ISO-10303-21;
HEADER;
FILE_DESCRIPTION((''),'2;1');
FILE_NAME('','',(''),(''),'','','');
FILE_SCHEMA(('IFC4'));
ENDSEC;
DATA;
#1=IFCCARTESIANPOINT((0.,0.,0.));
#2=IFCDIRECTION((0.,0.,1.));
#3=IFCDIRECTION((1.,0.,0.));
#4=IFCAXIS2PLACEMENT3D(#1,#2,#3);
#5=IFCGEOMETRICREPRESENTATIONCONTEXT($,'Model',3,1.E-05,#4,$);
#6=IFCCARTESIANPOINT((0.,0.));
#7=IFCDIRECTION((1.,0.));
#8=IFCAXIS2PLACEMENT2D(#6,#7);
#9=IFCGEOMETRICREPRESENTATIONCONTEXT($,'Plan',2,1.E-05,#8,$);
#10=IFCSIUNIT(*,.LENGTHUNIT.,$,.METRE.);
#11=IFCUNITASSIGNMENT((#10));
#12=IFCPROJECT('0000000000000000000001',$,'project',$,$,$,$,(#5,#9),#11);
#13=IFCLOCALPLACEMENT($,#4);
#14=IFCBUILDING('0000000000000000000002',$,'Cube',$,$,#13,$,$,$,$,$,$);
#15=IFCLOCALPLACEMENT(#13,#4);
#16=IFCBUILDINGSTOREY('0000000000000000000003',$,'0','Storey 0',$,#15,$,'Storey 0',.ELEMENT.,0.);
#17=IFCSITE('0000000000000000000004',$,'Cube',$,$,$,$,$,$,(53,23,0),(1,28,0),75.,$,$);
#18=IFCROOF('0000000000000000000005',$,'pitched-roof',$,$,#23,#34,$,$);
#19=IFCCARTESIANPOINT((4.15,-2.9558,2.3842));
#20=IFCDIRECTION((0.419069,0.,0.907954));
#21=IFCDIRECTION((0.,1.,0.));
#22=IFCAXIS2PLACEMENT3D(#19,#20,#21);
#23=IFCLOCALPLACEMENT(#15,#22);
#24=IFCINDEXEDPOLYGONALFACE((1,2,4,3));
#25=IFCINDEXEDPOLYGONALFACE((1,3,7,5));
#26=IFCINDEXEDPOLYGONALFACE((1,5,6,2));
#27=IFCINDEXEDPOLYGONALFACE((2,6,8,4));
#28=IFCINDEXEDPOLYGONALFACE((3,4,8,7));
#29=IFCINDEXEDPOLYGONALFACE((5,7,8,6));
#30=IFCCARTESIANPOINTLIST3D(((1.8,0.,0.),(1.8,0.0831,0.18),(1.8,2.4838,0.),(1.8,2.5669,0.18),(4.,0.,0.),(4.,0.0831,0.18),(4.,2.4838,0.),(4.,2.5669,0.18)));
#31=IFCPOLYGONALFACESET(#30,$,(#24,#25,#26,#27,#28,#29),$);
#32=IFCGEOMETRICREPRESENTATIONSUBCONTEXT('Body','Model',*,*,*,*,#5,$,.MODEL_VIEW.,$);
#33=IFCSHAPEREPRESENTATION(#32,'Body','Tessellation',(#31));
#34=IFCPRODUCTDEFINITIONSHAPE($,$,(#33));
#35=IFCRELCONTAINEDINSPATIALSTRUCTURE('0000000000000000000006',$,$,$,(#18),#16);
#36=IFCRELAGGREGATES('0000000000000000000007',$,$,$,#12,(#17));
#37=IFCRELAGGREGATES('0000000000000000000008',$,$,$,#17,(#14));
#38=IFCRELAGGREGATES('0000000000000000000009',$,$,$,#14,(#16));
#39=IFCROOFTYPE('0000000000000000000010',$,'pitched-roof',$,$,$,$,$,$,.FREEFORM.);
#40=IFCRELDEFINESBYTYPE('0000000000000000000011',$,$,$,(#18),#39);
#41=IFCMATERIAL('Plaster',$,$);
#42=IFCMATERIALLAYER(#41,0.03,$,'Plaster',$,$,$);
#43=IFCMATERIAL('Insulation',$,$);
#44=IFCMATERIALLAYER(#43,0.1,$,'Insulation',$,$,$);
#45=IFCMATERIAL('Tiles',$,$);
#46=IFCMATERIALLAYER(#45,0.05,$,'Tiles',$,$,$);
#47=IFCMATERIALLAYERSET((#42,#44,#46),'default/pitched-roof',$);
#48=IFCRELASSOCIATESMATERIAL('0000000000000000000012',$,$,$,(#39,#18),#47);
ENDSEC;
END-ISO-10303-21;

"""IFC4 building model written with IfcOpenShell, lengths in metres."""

from ifc_helpers import new_model, si_unit, frame, origin_with_axes, origin_2d_with_axis, place, context, subcontext, project, spatial, indexed_curve, outline, extrude, material, layer, layer_set, layer_usage, type_object, element, save


model = new_model("IFC4")

# Units and contexts
model_context = context("Model", 3, precision=1e-05, world=origin_with_axes())
plan_context = context("Plan", 2, precision=1e-05, world=origin_2d_with_axis())
body_context = subcontext(model_context, "Body", "Model", "MODEL_VIEW")
ifc_project = project(units=[si_unit("LENGTHUNIT", "METRE")], contexts=[model_context, plan_context])

# Site, building, storey
site = spatial("IfcSite", under=ifc_project, Name="Cube", RefLatitude=(53, 23, 0), RefLongitude=(1, 28, 0), RefElevation=75.0)
building_placement = place(None, origin_with_axes())
building = spatial("IfcBuilding", under=site, at=building_placement, Name="Cube")
storey_placement = place(building_placement, origin_with_axes())
storey = spatial("IfcBuildingStorey", under=building, at=storey_placement, Name="0", Description="Storey 0", LongName="Storey 0", CompositionType="ELEMENT", Elevation=0.0)

# Shared definitions
ifc_material_1 = material(Name="Plaster")

# Roof
ifc_layer_1 = layer(ifc_material_1, 0.03, Name="Plaster")
ifc_material_2 = material(Name="Insulation")
ifc_layer_2 = layer(ifc_material_2, 0.1, Name="Insulation")
ifc_material_3 = material(Name="Tiles")
ifc_layer_3 = layer(ifc_material_3, 0.05, Name="Tiles")
ifc_layer_set_1 = layer_set([ifc_layer_1, ifc_layer_2, ifc_layer_3], Name="default/pitched-roof")
ifc_layer_usage_1 = layer_usage(ifc_layer_set_1, "AXIS3", "POSITIVE", 0.0)
roof_type = type_object("IfcRoofType", Name="pitched-roof", PredefinedType="FREEFORM", material=ifc_layer_set_1)
roof_placement = place(storey_placement, frame((4.15, -2.9558, 2.3842), z_axis=(0.419069, 0.0, 0.907954), x_axis=(0.0, 1.0, 0.0)))
element("IfcRoof", 1, at=roof_placement, inside=storey, type_object=roof_type, material=ifc_layer_usage_1, Name="pitched-roof", context=body_context, shape_type="SweptSolid", body=[
    extrude(outline(indexed_curve([(4.0, 2.4838), (4.0, 0.0), (1.8, 0.0), (1.8, 2.4838)])), frame((0.0, 0.0, 0.0), z_axis=(0.0, 0.0, 1.0), x_axis=(1.0, 0.0, 0.0)), (0.0, 0.419069, 0.907954), 0.1982),
])

save(model, "model.ifc")
